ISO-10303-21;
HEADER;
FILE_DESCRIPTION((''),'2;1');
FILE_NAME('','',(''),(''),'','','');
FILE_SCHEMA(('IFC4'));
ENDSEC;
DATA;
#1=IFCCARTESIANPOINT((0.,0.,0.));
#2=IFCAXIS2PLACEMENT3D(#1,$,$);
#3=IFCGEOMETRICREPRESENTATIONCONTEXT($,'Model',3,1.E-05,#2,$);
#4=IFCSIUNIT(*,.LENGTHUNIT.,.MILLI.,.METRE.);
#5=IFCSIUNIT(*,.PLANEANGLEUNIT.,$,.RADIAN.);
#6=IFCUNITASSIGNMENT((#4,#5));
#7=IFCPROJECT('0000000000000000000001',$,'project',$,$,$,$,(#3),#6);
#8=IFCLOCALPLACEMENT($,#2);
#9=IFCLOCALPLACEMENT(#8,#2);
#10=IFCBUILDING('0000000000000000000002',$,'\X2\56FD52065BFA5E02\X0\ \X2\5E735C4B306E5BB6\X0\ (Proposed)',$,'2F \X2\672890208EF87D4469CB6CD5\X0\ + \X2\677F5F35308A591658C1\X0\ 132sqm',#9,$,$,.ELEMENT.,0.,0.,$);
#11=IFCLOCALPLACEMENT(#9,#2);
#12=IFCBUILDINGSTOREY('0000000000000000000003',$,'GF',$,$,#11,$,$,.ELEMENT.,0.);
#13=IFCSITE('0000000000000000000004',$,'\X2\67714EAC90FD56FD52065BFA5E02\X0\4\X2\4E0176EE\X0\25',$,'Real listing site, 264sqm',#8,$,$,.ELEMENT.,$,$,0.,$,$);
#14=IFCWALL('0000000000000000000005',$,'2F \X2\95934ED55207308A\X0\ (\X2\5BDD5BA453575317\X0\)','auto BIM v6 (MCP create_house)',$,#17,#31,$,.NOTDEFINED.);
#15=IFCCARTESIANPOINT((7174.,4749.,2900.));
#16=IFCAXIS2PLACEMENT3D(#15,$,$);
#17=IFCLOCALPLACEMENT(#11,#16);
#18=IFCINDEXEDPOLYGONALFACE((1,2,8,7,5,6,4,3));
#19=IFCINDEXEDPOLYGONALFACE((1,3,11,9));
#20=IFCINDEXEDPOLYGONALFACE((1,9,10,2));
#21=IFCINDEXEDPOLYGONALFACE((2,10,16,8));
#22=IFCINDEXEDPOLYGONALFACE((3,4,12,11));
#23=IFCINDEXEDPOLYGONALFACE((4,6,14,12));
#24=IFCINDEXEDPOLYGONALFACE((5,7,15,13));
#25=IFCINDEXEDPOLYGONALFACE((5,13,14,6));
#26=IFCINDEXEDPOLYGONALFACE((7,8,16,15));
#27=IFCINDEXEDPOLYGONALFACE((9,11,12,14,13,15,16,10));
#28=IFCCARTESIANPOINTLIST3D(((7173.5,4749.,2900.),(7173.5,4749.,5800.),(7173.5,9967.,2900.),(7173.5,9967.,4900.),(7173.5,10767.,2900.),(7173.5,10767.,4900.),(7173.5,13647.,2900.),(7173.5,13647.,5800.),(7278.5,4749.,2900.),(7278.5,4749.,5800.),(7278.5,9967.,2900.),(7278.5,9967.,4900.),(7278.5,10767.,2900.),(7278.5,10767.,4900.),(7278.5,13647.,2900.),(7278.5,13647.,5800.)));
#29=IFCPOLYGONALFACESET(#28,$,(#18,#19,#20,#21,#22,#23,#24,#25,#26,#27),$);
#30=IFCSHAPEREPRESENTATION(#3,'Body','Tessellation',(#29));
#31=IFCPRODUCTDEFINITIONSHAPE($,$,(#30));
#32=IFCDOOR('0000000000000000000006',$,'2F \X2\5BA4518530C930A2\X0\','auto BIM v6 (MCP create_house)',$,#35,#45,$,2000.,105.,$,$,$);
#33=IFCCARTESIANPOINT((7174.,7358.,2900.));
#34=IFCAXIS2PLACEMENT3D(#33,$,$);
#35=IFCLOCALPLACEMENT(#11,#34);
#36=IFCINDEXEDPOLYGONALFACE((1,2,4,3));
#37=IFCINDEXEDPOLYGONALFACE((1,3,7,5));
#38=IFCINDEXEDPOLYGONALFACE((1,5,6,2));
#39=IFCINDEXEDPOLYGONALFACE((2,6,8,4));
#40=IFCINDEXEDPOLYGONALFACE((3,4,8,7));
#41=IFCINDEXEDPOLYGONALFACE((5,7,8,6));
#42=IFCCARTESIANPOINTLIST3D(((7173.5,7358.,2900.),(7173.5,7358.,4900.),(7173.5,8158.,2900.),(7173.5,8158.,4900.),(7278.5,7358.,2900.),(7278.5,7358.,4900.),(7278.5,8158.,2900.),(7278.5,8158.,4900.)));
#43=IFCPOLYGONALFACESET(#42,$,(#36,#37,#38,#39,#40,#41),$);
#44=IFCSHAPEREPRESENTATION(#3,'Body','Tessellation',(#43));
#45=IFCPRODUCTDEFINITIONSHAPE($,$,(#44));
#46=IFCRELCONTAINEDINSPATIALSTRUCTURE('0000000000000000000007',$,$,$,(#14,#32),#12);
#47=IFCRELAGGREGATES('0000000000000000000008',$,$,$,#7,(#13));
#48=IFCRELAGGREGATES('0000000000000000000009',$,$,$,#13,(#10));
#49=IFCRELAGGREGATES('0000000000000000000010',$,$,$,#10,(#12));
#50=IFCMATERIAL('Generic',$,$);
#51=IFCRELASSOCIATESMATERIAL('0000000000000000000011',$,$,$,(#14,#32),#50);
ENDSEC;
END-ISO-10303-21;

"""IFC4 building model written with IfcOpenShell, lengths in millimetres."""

from ifc_helpers import new_model, si_unit, frame, frame_2d, origin, place, context, project, spatial, rectangle, extrude, material, element, fill, save


model = new_model("IFC4")

# Units and contexts
model_context = context("Model", 3, precision=1e-05, world=origin())
ifc_project = project(units=[si_unit("LENGTHUNIT", "METRE", prefix="MILLI"), si_unit("PLANEANGLEUNIT", "RADIAN")], contexts=[model_context])

# Site, building, storey
site_placement = place(None, origin())
site = spatial("IfcSite", under=ifc_project, at=site_placement, Name="東京都国分寺市4丁目25", ObjectType="Real listing site, 264sqm", CompositionType="ELEMENT", RefElevation=0.0)
building_placement = place(site_placement, origin())
building = spatial("IfcBuilding", under=site, at=building_placement, Name="国分寺市 平屋の家 (Proposed)", ObjectType="2F 木造軸組構法 + 板張り外壁 132sqm", CompositionType="ELEMENT", ElevationOfRefHeight=0.0, ElevationOfTerrain=0.0)
storey_placement = place(building_placement, origin())
storey = spatial("IfcBuildingStorey", under=building, at=storey_placement, Name="GF", CompositionType="ELEMENT", Elevation=0.0)

# Shared definitions
ifc_material = material(Name="Generic")

# Wall, opening, door
wall_1_placement = place(storey_placement, frame((7174.0, 4749.0, 2900.0)))
wall_1 = element("IfcWall", 1, at=wall_1_placement, inside=storey, material=ifc_material, Name="2F 間仕切り (寝室南北)", Description="auto BIM v6 (MCP create_house)", PredefinedType="NOTDEFINED", context=model_context, shape_type="SweptSolid", body=[
    extrude(rectangle(XDim=105.0, YDim=8898.0, at=frame_2d((52.0, 4449.0))), frame((7174.0, 4749.0, 2900.0)), (0.0, 0.0, 1.0), 2900.0),
])
opening_1_placement = place(storey_placement, frame((7174.0, 7358.0, 2900.0)))
opening_1 = element("IfcOpeningElement", 2, at=opening_1_placement, cuts=wall_1, PredefinedType="NOTDEFINED", context=model_context, shape_type="SweptSolid", body=[
    extrude(rectangle(XDim=105.0, YDim=800.0, at=frame_2d((52.0, 400.0))), frame((7174.0, 7358.0, 2900.0)), (0.0, 0.0, 1.0), 2000.0),
])
door_placement = place(storey_placement, frame((7174.0, 7358.0, 2900.0)))
door = element("IfcDoor", 3, at=door_placement, inside=storey, material=ifc_material, Name="2F 室内ドア", Description="auto BIM v6 (MCP create_house)", OverallHeight=2000.0, OverallWidth=105.0, context=model_context, shape_type="SweptSolid", body=[
    extrude(rectangle(XDim=105.0, YDim=800.0, at=frame_2d((52.0, 400.0))), frame((7174.0, 7358.0, 2900.0)), (0.0, 0.0, 1.0), 2000.0),
])
fill(opening_1, door)

save(model, "model.ifc")
